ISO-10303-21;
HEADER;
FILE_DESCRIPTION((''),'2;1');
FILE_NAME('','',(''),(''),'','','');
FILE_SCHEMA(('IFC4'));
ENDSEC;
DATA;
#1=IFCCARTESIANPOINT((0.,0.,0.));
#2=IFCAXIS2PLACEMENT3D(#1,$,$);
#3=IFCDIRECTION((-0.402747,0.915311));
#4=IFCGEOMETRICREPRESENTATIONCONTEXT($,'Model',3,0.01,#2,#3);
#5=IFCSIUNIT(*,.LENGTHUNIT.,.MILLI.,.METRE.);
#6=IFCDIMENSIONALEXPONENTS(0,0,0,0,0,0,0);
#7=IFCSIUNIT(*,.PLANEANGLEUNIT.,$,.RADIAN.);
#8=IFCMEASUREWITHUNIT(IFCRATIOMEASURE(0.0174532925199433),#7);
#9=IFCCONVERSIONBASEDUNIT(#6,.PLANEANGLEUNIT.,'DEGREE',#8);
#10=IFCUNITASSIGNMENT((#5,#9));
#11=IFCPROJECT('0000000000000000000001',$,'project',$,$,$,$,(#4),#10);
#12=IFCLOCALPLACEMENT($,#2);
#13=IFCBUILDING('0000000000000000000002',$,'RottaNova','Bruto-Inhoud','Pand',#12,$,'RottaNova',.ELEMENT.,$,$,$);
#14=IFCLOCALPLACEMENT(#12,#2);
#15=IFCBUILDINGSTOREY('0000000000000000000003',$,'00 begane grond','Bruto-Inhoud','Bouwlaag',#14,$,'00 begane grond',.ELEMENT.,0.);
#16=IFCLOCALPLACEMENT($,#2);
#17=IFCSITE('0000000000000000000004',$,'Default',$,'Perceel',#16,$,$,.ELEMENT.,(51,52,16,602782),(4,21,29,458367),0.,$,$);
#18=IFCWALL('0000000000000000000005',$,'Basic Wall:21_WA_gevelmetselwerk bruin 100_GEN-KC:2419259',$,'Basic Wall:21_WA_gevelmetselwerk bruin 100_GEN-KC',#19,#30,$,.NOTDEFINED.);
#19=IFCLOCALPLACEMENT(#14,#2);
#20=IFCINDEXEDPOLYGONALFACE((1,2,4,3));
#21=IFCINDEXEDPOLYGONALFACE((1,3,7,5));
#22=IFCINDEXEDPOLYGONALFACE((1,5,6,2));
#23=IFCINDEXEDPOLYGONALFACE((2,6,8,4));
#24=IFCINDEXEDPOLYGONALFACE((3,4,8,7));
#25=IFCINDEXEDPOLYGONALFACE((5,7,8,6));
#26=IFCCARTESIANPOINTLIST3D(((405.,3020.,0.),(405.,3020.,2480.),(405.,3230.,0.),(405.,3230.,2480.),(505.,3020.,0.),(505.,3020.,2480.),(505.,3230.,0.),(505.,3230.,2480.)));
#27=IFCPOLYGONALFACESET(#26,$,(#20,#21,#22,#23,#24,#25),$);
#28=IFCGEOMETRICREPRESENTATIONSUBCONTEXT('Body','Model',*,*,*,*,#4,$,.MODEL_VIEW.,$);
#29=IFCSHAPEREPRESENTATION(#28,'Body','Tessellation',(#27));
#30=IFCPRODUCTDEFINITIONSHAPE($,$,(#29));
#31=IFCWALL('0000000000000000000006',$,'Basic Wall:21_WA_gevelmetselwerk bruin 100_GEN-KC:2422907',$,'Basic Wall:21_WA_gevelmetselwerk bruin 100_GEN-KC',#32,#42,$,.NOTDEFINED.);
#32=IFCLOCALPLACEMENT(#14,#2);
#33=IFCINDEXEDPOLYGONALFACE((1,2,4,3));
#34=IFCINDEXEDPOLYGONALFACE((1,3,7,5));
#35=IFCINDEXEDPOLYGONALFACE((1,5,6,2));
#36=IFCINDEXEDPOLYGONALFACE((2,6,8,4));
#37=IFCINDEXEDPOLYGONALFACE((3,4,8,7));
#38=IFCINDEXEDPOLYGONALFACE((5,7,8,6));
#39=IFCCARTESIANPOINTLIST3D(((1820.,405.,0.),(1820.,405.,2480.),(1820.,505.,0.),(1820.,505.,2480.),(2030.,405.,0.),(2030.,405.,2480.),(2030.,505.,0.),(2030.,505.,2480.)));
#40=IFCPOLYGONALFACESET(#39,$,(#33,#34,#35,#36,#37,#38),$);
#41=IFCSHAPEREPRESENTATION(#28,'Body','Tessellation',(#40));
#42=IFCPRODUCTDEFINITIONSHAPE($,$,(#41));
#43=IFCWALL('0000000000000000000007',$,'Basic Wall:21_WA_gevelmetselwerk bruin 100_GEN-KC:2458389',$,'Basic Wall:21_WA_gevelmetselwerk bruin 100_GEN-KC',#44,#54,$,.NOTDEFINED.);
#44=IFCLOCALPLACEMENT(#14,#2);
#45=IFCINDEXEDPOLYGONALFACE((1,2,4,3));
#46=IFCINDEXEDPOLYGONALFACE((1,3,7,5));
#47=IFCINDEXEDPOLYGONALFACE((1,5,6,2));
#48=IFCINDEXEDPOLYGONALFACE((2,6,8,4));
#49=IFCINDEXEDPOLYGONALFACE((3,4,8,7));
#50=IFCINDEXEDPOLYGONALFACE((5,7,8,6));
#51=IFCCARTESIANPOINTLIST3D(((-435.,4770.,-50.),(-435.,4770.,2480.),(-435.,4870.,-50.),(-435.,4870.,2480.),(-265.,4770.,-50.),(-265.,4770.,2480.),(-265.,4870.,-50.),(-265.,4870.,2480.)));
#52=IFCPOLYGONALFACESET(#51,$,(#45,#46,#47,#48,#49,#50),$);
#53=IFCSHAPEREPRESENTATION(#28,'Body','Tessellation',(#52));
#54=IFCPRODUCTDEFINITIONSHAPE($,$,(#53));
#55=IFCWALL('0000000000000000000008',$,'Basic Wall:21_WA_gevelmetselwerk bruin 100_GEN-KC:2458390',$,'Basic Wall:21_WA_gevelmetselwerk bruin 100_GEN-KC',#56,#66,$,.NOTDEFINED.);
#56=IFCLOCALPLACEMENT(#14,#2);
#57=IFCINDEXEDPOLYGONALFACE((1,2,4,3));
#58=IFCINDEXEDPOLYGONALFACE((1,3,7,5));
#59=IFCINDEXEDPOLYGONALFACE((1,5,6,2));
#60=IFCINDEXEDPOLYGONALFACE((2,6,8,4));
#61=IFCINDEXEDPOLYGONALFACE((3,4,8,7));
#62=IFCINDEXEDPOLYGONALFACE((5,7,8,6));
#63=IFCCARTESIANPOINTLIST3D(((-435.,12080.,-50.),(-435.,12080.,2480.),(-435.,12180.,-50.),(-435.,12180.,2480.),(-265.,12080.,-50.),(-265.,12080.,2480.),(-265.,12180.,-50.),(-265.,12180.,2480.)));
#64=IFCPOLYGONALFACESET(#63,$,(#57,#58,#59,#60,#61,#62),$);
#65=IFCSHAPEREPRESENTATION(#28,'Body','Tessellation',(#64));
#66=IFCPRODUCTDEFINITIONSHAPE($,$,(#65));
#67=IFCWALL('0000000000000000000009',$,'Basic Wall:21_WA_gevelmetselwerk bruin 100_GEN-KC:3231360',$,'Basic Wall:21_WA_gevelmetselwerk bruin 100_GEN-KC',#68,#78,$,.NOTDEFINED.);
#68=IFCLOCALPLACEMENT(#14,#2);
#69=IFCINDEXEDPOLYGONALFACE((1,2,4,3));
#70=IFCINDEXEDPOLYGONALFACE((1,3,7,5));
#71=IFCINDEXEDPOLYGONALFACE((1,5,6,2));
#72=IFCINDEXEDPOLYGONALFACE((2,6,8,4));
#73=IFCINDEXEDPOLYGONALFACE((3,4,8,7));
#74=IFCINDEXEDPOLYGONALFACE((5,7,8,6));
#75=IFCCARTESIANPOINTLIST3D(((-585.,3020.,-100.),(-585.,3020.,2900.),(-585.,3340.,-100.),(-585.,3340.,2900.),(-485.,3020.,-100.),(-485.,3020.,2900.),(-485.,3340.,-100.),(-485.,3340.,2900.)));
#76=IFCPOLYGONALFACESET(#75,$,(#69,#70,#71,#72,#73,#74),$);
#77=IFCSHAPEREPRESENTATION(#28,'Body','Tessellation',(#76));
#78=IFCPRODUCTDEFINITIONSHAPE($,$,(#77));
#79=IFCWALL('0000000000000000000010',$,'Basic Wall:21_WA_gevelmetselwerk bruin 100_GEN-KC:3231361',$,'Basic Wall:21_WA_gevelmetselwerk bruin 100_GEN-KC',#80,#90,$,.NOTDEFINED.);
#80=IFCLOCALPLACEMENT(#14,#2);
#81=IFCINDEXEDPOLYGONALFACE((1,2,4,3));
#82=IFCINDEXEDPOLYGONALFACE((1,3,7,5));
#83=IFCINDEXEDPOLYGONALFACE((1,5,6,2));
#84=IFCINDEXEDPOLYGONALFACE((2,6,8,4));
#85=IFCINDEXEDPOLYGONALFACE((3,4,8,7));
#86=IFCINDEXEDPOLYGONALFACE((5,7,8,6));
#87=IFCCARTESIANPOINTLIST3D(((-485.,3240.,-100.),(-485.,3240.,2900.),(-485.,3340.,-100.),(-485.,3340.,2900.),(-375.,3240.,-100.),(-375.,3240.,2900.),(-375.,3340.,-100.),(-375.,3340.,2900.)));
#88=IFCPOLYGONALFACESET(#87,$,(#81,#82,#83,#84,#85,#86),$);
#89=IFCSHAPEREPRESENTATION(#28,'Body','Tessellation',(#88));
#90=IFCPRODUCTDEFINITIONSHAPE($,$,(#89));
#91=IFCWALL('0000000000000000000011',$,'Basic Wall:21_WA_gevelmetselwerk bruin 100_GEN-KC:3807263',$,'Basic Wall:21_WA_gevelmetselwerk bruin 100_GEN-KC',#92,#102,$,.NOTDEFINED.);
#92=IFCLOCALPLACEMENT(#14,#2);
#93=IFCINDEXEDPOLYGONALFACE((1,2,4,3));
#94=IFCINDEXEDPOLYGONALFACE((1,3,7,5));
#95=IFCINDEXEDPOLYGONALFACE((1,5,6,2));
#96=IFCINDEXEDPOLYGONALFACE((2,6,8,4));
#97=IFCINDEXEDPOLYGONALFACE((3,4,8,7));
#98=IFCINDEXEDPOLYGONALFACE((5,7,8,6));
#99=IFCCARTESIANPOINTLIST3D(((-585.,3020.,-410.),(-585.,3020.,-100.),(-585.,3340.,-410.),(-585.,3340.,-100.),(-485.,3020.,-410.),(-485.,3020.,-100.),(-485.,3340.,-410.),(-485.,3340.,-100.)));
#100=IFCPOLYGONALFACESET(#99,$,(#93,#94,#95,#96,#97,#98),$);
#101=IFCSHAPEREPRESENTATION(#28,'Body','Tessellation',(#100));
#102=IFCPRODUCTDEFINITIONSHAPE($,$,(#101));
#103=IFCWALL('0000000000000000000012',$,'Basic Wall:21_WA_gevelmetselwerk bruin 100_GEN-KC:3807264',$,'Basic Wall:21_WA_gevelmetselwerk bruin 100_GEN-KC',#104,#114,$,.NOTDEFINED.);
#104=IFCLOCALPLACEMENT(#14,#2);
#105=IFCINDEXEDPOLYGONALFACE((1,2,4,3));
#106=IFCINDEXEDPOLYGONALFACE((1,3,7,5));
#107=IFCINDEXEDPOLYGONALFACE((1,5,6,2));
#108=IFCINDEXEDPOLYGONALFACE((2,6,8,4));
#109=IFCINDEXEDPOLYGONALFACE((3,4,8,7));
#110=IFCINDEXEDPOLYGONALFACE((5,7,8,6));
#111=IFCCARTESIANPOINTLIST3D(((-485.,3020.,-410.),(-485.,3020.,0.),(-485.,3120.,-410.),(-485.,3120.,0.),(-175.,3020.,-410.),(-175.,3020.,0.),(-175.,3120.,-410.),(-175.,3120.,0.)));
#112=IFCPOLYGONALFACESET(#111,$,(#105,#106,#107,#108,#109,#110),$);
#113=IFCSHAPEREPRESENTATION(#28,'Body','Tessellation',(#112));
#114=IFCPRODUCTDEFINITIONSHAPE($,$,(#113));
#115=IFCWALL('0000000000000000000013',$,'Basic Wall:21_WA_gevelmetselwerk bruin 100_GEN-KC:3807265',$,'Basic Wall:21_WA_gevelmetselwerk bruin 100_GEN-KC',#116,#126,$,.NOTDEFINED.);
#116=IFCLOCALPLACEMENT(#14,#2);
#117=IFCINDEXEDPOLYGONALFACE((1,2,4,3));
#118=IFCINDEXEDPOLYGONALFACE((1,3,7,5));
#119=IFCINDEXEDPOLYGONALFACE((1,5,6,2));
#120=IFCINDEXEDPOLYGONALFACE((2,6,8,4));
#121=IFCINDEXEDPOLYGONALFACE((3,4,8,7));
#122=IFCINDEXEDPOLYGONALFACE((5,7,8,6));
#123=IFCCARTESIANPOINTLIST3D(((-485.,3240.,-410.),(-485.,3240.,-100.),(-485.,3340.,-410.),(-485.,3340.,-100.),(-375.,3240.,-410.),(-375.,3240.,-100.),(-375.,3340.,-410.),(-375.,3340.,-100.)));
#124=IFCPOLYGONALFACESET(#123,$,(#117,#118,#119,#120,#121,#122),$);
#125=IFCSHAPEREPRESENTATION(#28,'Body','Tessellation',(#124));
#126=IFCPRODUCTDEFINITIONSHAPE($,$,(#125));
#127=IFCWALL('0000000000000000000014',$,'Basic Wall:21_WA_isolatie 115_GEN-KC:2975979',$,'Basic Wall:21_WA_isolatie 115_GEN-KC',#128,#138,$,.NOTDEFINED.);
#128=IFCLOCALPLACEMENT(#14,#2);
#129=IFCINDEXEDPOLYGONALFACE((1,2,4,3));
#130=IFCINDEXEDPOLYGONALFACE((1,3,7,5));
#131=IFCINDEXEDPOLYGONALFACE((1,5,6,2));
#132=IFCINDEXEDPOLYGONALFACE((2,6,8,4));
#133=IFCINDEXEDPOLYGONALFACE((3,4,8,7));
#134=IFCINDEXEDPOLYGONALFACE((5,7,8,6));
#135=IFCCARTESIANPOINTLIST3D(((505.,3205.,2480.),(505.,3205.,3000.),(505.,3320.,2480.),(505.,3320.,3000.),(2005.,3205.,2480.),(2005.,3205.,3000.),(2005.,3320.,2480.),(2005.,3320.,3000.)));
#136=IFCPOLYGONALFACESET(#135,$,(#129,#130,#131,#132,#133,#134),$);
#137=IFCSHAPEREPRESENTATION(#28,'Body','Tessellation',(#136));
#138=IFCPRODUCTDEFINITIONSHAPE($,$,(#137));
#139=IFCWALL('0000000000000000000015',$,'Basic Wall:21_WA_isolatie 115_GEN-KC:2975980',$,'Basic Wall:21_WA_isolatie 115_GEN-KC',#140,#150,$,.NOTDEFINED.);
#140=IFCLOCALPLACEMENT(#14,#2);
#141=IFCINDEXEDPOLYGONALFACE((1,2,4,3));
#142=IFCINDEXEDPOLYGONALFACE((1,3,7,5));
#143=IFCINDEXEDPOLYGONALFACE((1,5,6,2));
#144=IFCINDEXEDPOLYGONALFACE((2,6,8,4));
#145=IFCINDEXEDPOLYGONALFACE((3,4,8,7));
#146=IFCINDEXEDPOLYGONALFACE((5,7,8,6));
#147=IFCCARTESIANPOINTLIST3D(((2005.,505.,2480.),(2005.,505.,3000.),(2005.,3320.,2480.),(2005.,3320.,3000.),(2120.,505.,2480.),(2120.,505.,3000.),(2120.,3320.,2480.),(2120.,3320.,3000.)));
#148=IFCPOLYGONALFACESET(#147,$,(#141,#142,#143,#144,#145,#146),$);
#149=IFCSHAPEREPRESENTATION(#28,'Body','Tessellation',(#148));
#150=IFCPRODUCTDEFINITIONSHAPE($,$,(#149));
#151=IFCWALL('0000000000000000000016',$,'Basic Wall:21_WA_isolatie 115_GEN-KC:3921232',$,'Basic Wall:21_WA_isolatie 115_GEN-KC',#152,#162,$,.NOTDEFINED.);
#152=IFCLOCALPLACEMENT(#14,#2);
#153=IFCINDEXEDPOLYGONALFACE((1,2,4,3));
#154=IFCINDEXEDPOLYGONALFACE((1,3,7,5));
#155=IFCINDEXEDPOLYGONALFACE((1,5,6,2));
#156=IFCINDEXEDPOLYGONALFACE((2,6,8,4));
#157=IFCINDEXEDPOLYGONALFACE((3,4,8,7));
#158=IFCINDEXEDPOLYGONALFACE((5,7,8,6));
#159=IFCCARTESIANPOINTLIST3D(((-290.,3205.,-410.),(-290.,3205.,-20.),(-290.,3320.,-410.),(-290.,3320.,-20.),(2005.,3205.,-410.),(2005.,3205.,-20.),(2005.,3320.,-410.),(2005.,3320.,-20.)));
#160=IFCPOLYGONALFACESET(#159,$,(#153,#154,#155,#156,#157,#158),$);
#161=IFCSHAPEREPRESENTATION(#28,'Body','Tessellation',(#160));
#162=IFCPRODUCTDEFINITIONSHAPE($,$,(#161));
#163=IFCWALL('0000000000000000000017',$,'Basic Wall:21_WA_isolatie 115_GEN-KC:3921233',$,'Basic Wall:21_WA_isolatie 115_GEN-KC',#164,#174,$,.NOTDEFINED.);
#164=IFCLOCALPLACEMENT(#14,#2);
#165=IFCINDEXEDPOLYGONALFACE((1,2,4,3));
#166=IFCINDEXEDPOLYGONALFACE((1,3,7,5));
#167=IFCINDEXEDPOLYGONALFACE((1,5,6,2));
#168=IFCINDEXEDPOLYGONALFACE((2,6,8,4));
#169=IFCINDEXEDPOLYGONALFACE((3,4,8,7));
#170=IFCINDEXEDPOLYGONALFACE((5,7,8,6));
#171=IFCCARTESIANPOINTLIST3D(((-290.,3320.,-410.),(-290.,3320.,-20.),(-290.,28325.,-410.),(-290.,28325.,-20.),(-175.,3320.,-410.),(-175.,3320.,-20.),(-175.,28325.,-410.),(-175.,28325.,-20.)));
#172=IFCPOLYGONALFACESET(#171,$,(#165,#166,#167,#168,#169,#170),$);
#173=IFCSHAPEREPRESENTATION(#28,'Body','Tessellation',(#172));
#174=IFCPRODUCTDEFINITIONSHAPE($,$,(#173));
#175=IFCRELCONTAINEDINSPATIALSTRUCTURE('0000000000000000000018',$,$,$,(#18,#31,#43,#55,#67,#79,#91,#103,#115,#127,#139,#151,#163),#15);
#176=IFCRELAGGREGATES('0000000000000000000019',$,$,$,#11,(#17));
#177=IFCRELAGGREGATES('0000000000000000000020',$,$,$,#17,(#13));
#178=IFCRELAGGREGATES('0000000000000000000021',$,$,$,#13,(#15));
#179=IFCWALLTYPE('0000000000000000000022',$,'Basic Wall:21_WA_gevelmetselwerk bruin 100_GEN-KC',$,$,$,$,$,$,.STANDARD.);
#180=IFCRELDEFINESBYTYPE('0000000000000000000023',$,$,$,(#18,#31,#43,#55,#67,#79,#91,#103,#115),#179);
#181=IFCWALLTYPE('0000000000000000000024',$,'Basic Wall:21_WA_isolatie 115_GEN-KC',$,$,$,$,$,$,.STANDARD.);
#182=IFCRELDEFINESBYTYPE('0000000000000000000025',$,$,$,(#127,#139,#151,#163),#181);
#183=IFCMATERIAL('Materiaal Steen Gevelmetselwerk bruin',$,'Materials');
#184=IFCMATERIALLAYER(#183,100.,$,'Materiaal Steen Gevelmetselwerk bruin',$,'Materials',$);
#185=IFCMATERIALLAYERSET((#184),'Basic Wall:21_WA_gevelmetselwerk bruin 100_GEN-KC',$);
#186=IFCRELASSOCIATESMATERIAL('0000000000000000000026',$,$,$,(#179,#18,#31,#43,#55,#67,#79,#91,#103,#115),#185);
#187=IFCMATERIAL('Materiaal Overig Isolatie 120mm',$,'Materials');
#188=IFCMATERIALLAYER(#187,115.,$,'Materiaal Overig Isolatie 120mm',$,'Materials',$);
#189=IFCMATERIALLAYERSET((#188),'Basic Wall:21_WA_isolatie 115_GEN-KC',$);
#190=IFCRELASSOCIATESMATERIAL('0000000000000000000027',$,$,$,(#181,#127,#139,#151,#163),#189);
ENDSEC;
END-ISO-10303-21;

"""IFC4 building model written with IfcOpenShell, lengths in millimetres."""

from ifc_helpers import new_model, entity, si_unit, converted_unit, direction, frame, frame_2d, origin, place, context, subcontext, project, spatial, rectangle, extrude, material, layer, layer_set, type_object, element, save


model = new_model("IFC4")

# Units and contexts
model_context = context("Model", 3, precision=0.01, world=origin(), true_north=direction((-0.402747, 0.915311)))
body_context = subcontext(model_context, "Body", "Model", "MODEL_VIEW")
ifc_project = project(units=[si_unit("LENGTHUNIT", "METRE", prefix="MILLI"), converted_unit("PLANEANGLEUNIT", "DEGREE", entity("IfcRatioMeasure", 0.0174532925199433), si_unit("PLANEANGLEUNIT", "RADIAN"), dimensions=[0, 0, 0, 0, 0, 0, 0])], contexts=[model_context])

# Site, building, storey
site_placement = place(None, origin())
site = spatial("IfcSite", under=ifc_project, at=site_placement, Name="Default", ObjectType="Perceel", CompositionType="ELEMENT", RefLatitude=(51, 52, 16, 602782), RefLongitude=(4, 21, 29, 458367), RefElevation=0.0)
building_placement = place(None, origin())
building = spatial("IfcBuilding", under=site, at=building_placement, Name="RottaNova", Description="Bruto-Inhoud", ObjectType="Pand", LongName="RottaNova", CompositionType="ELEMENT")
storey_placement = place(building_placement, origin())
storey = spatial("IfcBuildingStorey", under=building, at=storey_placement, Name="00 begane grond", Description="Bruto-Inhoud", ObjectType="Bouwlaag", LongName="00 begane grond", CompositionType="ELEMENT", Elevation=0.0)

# Walls
ifc_material_1 = material(Name="Materiaal Steen Gevelmetselwerk bruin", Category="Materials")
ifc_layer_1 = layer(ifc_material_1, 100.0, Name="Materiaal Steen Gevelmetselwerk bruin", Category="Materials")
ifc_layer_set_1 = layer_set([ifc_layer_1], Name="Basic Wall:21_WA_gevelmetselwerk bruin 100_GEN-KC")
wall_type_1 = type_object("IfcWallType", Name="Basic Wall:21_WA_gevelmetselwerk bruin 100_GEN-KC", PredefinedType="STANDARD", material=ifc_layer_set_1)
wall_1_placement = place(storey_placement, frame((455.0, 3230.0, 0.0), z_axis=(0.0, 0.0, 1.0), x_axis=(0.0, -1.0, 0.0)))
element("IfcWall", 1, at=wall_1_placement, inside=storey, type_object=wall_type_1, material=ifc_layer_set_1, Name="Basic Wall:21_WA_gevelmetselwerk bruin 100_GEN-KC:2419259", ObjectType="Basic Wall:21_WA_gevelmetselwerk bruin 100_GEN-KC", PredefinedType="NOTDEFINED", context=body_context, shape_type="SweptSolid", body=[
    extrude(rectangle(XDim=210.0, YDim=100.0, at=frame_2d((105.0, 0.0), x_axis=(-1.0, 0.0))), origin(), (0.0, 0.0, 1.0), 2480.0),
])
wall_2_placement = place(storey_placement, frame((2030.0, 455.0, 0.0), z_axis=(0.0, 0.0, 1.0), x_axis=(-1.0, 0.0, 0.0)))
element("IfcWall", 2, at=wall_2_placement, inside=storey, type_object=wall_type_1, material=ifc_layer_set_1, Name="Basic Wall:21_WA_gevelmetselwerk bruin 100_GEN-KC:2422907", ObjectType="Basic Wall:21_WA_gevelmetselwerk bruin 100_GEN-KC", PredefinedType="NOTDEFINED", context=body_context, shape_type="SweptSolid", body=[
    extrude(rectangle(XDim=210.0, YDim=100.0, at=frame_2d((105.0, 0.0), x_axis=(-1.0, 0.0))), origin(), (0.0, 0.0, 1.0), 2480.0),
])
wall_3_placement = place(storey_placement, frame((-435.0, 4820.0, -50.0)))
element("IfcWall", 3, at=wall_3_placement, inside=storey, type_object=wall_type_1, material=ifc_layer_set_1, Name="Basic Wall:21_WA_gevelmetselwerk bruin 100_GEN-KC:2458389", ObjectType="Basic Wall:21_WA_gevelmetselwerk bruin 100_GEN-KC", PredefinedType="NOTDEFINED", context=body_context, shape_type="SweptSolid", body=[
    extrude(rectangle(XDim=170.0, YDim=100.0, at=frame_2d((85.0, 0.0), x_axis=(-1.0, 0.0))), origin(), (0.0, 0.0, 1.0), 2530.0),
])
wall_4_placement = place(storey_placement, frame((-435.0, 12130.0, -50.0)))
element("IfcWall", 4, at=wall_4_placement, inside=storey, type_object=wall_type_1, material=ifc_layer_set_1, Name="Basic Wall:21_WA_gevelmetselwerk bruin 100_GEN-KC:2458390", ObjectType="Basic Wall:21_WA_gevelmetselwerk bruin 100_GEN-KC", PredefinedType="NOTDEFINED", context=body_context, shape_type="SweptSolid", body=[
    extrude(rectangle(XDim=170.0, YDim=100.0, at=frame_2d((85.0, 0.0), x_axis=(-1.0, 0.0))), origin(), (0.0, 0.0, 1.0), 2530.0),
])
wall_5_placement = place(storey_placement, frame((-535.0, 3340.0, -100.0), z_axis=(0.0, 0.0, 1.0), x_axis=(0.0, -1.0, 0.0)))
element("IfcWall", 5, at=wall_5_placement, inside=storey, type_object=wall_type_1, material=ifc_layer_set_1, Name="Basic Wall:21_WA_gevelmetselwerk bruin 100_GEN-KC:3231360", ObjectType="Basic Wall:21_WA_gevelmetselwerk bruin 100_GEN-KC", PredefinedType="NOTDEFINED", context=body_context, shape_type="SweptSolid", body=[
    extrude(rectangle(XDim=320.0, YDim=100.0, at=frame_2d((160.0, 0.0), x_axis=(-1.0, 0.0))), origin(), (0.0, 0.0, 1.0), 3000.0),
])
wall_6_placement = place(storey_placement, frame((-485.0, 3290.0, -100.0)))
element("IfcWall", 6, at=wall_6_placement, inside=storey, type_object=wall_type_1, material=ifc_layer_set_1, Name="Basic Wall:21_WA_gevelmetselwerk bruin 100_GEN-KC:3231361", ObjectType="Basic Wall:21_WA_gevelmetselwerk bruin 100_GEN-KC", PredefinedType="NOTDEFINED", context=body_context, shape_type="SweptSolid", body=[
    extrude(rectangle(XDim=110.0, YDim=100.0, at=frame_2d((55.0, 0.0), x_axis=(-1.0, 0.0))), origin(), (0.0, 0.0, 1.0), 3000.0),
])
wall_7_placement = place(storey_placement, frame((-535.0, 3340.0, -410.0), z_axis=(0.0, 0.0, 1.0), x_axis=(0.0, -1.0, 0.0)))
element("IfcWall", 7, at=wall_7_placement, inside=storey, type_object=wall_type_1, material=ifc_layer_set_1, Name="Basic Wall:21_WA_gevelmetselwerk bruin 100_GEN-KC:3807263", ObjectType="Basic Wall:21_WA_gevelmetselwerk bruin 100_GEN-KC", PredefinedType="NOTDEFINED", context=body_context, shape_type="SweptSolid", body=[
    extrude(rectangle(XDim=320.0, YDim=100.0, at=frame_2d((160.0, 0.0), x_axis=(-1.0, 0.0))), origin(), (0.0, 0.0, 1.0), 310.0),
])
wall_8_placement = place(storey_placement, frame((-175.0, 3070.0, -410.0), z_axis=(0.0, 0.0, 1.0), x_axis=(-1.0, 0.0, 0.0)))
element("IfcWall", 8, at=wall_8_placement, inside=storey, type_object=wall_type_1, material=ifc_layer_set_1, Name="Basic Wall:21_WA_gevelmetselwerk bruin 100_GEN-KC:3807264", ObjectType="Basic Wall:21_WA_gevelmetselwerk bruin 100_GEN-KC", PredefinedType="NOTDEFINED", context=body_context, shape_type="SweptSolid", body=[
    extrude(rectangle(XDim=310.0, YDim=100.0, at=frame_2d((155.0, 0.0), x_axis=(-1.0, 0.0))), origin(), (0.0, 0.0, 1.0), 410.0),
])
wall_9_placement = place(storey_placement, frame((-485.0, 3290.0, -410.0)))
element("IfcWall", 9, at=wall_9_placement, inside=storey, type_object=wall_type_1, material=ifc_layer_set_1, Name="Basic Wall:21_WA_gevelmetselwerk bruin 100_GEN-KC:3807265", ObjectType="Basic Wall:21_WA_gevelmetselwerk bruin 100_GEN-KC", PredefinedType="NOTDEFINED", context=body_context, shape_type="SweptSolid", body=[
    extrude(rectangle(XDim=110.0, YDim=100.0, at=frame_2d((55.0, 0.0), x_axis=(-1.0, 0.0))), origin(), (0.0, 0.0, 1.0), 310.0),
])
ifc_material_2 = material(Name="Materiaal Overig Isolatie 120mm", Category="Materials")
ifc_layer_2 = layer(ifc_material_2, 115.0, Name="Materiaal Overig Isolatie 120mm", Category="Materials")
ifc_layer_set_2 = layer_set([ifc_layer_2], Name="Basic Wall:21_WA_isolatie 115_GEN-KC")
wall_type_2 = type_object("IfcWallType", Name="Basic Wall:21_WA_isolatie 115_GEN-KC", PredefinedType="STANDARD", material=ifc_layer_set_2)
wall_10_placement = place(storey_placement, frame((505.0, 3262.5, 2480.0)))
element("IfcWall", 10, at=wall_10_placement, inside=storey, type_object=wall_type_2, material=ifc_layer_set_2, Name="Basic Wall:21_WA_isolatie 115_GEN-KC:2975979", ObjectType="Basic Wall:21_WA_isolatie 115_GEN-KC", PredefinedType="NOTDEFINED", context=body_context, shape_type="SweptSolid", body=[
    extrude(rectangle(XDim=1500.0, YDim=115.0, at=frame_2d((750.0, 0.0), x_axis=(-1.0, 0.0))), origin(), (0.0, 0.0, 1.0), 520.0),
])
wall_11_placement = place(storey_placement, frame((2062.5, 3320.0, 2480.0), z_axis=(0.0, 0.0, 1.0), x_axis=(0.0, -1.0, 0.0)))
element("IfcWall", 11, at=wall_11_placement, inside=storey, type_object=wall_type_2, material=ifc_layer_set_2, Name="Basic Wall:21_WA_isolatie 115_GEN-KC:2975980", ObjectType="Basic Wall:21_WA_isolatie 115_GEN-KC", PredefinedType="NOTDEFINED", context=body_context, shape_type="SweptSolid", body=[
    extrude(rectangle(XDim=2815.0, YDim=115.0, at=frame_2d((1407.5, 0.0), x_axis=(-1.0, 0.0))), origin(), (0.0, 0.0, 1.0), 520.0),
])
wall_12_placement = place(storey_placement, frame((2005.0, 3262.5, -410.0), z_axis=(0.0, 0.0, 1.0), x_axis=(-1.0, 0.0, 0.0)))
element("IfcWall", 12, at=wall_12_placement, inside=storey, type_object=wall_type_2, material=ifc_layer_set_2, Name="Basic Wall:21_WA_isolatie 115_GEN-KC:3921232", ObjectType="Basic Wall:21_WA_isolatie 115_GEN-KC", PredefinedType="NOTDEFINED", context=body_context, shape_type="SweptSolid", body=[
    extrude(rectangle(XDim=2295.0, YDim=115.0, at=frame_2d((1147.5, 0.0), x_axis=(-1.0, 0.0))), origin(), (0.0, 0.0, 1.0), 390.0),
])
wall_13_placement = place(storey_placement, frame((-232.5, 3320.0, -410.0), z_axis=(0.0, 0.0, 1.0), x_axis=(0.0, 1.0, 0.0)))
element("IfcWall", 13, at=wall_13_placement, inside=storey, type_object=wall_type_2, material=ifc_layer_set_2, Name="Basic Wall:21_WA_isolatie 115_GEN-KC:3921233", ObjectType="Basic Wall:21_WA_isolatie 115_GEN-KC", PredefinedType="NOTDEFINED", context=body_context, shape_type="SweptSolid", body=[
    extrude(rectangle(XDim=25005.0, YDim=115.0, at=frame_2d((12502.5, 0.0), x_axis=(-1.0, 0.0))), origin(), (0.0, 0.0, 1.0), 390.0),
])

save(model, "model.ifc")
